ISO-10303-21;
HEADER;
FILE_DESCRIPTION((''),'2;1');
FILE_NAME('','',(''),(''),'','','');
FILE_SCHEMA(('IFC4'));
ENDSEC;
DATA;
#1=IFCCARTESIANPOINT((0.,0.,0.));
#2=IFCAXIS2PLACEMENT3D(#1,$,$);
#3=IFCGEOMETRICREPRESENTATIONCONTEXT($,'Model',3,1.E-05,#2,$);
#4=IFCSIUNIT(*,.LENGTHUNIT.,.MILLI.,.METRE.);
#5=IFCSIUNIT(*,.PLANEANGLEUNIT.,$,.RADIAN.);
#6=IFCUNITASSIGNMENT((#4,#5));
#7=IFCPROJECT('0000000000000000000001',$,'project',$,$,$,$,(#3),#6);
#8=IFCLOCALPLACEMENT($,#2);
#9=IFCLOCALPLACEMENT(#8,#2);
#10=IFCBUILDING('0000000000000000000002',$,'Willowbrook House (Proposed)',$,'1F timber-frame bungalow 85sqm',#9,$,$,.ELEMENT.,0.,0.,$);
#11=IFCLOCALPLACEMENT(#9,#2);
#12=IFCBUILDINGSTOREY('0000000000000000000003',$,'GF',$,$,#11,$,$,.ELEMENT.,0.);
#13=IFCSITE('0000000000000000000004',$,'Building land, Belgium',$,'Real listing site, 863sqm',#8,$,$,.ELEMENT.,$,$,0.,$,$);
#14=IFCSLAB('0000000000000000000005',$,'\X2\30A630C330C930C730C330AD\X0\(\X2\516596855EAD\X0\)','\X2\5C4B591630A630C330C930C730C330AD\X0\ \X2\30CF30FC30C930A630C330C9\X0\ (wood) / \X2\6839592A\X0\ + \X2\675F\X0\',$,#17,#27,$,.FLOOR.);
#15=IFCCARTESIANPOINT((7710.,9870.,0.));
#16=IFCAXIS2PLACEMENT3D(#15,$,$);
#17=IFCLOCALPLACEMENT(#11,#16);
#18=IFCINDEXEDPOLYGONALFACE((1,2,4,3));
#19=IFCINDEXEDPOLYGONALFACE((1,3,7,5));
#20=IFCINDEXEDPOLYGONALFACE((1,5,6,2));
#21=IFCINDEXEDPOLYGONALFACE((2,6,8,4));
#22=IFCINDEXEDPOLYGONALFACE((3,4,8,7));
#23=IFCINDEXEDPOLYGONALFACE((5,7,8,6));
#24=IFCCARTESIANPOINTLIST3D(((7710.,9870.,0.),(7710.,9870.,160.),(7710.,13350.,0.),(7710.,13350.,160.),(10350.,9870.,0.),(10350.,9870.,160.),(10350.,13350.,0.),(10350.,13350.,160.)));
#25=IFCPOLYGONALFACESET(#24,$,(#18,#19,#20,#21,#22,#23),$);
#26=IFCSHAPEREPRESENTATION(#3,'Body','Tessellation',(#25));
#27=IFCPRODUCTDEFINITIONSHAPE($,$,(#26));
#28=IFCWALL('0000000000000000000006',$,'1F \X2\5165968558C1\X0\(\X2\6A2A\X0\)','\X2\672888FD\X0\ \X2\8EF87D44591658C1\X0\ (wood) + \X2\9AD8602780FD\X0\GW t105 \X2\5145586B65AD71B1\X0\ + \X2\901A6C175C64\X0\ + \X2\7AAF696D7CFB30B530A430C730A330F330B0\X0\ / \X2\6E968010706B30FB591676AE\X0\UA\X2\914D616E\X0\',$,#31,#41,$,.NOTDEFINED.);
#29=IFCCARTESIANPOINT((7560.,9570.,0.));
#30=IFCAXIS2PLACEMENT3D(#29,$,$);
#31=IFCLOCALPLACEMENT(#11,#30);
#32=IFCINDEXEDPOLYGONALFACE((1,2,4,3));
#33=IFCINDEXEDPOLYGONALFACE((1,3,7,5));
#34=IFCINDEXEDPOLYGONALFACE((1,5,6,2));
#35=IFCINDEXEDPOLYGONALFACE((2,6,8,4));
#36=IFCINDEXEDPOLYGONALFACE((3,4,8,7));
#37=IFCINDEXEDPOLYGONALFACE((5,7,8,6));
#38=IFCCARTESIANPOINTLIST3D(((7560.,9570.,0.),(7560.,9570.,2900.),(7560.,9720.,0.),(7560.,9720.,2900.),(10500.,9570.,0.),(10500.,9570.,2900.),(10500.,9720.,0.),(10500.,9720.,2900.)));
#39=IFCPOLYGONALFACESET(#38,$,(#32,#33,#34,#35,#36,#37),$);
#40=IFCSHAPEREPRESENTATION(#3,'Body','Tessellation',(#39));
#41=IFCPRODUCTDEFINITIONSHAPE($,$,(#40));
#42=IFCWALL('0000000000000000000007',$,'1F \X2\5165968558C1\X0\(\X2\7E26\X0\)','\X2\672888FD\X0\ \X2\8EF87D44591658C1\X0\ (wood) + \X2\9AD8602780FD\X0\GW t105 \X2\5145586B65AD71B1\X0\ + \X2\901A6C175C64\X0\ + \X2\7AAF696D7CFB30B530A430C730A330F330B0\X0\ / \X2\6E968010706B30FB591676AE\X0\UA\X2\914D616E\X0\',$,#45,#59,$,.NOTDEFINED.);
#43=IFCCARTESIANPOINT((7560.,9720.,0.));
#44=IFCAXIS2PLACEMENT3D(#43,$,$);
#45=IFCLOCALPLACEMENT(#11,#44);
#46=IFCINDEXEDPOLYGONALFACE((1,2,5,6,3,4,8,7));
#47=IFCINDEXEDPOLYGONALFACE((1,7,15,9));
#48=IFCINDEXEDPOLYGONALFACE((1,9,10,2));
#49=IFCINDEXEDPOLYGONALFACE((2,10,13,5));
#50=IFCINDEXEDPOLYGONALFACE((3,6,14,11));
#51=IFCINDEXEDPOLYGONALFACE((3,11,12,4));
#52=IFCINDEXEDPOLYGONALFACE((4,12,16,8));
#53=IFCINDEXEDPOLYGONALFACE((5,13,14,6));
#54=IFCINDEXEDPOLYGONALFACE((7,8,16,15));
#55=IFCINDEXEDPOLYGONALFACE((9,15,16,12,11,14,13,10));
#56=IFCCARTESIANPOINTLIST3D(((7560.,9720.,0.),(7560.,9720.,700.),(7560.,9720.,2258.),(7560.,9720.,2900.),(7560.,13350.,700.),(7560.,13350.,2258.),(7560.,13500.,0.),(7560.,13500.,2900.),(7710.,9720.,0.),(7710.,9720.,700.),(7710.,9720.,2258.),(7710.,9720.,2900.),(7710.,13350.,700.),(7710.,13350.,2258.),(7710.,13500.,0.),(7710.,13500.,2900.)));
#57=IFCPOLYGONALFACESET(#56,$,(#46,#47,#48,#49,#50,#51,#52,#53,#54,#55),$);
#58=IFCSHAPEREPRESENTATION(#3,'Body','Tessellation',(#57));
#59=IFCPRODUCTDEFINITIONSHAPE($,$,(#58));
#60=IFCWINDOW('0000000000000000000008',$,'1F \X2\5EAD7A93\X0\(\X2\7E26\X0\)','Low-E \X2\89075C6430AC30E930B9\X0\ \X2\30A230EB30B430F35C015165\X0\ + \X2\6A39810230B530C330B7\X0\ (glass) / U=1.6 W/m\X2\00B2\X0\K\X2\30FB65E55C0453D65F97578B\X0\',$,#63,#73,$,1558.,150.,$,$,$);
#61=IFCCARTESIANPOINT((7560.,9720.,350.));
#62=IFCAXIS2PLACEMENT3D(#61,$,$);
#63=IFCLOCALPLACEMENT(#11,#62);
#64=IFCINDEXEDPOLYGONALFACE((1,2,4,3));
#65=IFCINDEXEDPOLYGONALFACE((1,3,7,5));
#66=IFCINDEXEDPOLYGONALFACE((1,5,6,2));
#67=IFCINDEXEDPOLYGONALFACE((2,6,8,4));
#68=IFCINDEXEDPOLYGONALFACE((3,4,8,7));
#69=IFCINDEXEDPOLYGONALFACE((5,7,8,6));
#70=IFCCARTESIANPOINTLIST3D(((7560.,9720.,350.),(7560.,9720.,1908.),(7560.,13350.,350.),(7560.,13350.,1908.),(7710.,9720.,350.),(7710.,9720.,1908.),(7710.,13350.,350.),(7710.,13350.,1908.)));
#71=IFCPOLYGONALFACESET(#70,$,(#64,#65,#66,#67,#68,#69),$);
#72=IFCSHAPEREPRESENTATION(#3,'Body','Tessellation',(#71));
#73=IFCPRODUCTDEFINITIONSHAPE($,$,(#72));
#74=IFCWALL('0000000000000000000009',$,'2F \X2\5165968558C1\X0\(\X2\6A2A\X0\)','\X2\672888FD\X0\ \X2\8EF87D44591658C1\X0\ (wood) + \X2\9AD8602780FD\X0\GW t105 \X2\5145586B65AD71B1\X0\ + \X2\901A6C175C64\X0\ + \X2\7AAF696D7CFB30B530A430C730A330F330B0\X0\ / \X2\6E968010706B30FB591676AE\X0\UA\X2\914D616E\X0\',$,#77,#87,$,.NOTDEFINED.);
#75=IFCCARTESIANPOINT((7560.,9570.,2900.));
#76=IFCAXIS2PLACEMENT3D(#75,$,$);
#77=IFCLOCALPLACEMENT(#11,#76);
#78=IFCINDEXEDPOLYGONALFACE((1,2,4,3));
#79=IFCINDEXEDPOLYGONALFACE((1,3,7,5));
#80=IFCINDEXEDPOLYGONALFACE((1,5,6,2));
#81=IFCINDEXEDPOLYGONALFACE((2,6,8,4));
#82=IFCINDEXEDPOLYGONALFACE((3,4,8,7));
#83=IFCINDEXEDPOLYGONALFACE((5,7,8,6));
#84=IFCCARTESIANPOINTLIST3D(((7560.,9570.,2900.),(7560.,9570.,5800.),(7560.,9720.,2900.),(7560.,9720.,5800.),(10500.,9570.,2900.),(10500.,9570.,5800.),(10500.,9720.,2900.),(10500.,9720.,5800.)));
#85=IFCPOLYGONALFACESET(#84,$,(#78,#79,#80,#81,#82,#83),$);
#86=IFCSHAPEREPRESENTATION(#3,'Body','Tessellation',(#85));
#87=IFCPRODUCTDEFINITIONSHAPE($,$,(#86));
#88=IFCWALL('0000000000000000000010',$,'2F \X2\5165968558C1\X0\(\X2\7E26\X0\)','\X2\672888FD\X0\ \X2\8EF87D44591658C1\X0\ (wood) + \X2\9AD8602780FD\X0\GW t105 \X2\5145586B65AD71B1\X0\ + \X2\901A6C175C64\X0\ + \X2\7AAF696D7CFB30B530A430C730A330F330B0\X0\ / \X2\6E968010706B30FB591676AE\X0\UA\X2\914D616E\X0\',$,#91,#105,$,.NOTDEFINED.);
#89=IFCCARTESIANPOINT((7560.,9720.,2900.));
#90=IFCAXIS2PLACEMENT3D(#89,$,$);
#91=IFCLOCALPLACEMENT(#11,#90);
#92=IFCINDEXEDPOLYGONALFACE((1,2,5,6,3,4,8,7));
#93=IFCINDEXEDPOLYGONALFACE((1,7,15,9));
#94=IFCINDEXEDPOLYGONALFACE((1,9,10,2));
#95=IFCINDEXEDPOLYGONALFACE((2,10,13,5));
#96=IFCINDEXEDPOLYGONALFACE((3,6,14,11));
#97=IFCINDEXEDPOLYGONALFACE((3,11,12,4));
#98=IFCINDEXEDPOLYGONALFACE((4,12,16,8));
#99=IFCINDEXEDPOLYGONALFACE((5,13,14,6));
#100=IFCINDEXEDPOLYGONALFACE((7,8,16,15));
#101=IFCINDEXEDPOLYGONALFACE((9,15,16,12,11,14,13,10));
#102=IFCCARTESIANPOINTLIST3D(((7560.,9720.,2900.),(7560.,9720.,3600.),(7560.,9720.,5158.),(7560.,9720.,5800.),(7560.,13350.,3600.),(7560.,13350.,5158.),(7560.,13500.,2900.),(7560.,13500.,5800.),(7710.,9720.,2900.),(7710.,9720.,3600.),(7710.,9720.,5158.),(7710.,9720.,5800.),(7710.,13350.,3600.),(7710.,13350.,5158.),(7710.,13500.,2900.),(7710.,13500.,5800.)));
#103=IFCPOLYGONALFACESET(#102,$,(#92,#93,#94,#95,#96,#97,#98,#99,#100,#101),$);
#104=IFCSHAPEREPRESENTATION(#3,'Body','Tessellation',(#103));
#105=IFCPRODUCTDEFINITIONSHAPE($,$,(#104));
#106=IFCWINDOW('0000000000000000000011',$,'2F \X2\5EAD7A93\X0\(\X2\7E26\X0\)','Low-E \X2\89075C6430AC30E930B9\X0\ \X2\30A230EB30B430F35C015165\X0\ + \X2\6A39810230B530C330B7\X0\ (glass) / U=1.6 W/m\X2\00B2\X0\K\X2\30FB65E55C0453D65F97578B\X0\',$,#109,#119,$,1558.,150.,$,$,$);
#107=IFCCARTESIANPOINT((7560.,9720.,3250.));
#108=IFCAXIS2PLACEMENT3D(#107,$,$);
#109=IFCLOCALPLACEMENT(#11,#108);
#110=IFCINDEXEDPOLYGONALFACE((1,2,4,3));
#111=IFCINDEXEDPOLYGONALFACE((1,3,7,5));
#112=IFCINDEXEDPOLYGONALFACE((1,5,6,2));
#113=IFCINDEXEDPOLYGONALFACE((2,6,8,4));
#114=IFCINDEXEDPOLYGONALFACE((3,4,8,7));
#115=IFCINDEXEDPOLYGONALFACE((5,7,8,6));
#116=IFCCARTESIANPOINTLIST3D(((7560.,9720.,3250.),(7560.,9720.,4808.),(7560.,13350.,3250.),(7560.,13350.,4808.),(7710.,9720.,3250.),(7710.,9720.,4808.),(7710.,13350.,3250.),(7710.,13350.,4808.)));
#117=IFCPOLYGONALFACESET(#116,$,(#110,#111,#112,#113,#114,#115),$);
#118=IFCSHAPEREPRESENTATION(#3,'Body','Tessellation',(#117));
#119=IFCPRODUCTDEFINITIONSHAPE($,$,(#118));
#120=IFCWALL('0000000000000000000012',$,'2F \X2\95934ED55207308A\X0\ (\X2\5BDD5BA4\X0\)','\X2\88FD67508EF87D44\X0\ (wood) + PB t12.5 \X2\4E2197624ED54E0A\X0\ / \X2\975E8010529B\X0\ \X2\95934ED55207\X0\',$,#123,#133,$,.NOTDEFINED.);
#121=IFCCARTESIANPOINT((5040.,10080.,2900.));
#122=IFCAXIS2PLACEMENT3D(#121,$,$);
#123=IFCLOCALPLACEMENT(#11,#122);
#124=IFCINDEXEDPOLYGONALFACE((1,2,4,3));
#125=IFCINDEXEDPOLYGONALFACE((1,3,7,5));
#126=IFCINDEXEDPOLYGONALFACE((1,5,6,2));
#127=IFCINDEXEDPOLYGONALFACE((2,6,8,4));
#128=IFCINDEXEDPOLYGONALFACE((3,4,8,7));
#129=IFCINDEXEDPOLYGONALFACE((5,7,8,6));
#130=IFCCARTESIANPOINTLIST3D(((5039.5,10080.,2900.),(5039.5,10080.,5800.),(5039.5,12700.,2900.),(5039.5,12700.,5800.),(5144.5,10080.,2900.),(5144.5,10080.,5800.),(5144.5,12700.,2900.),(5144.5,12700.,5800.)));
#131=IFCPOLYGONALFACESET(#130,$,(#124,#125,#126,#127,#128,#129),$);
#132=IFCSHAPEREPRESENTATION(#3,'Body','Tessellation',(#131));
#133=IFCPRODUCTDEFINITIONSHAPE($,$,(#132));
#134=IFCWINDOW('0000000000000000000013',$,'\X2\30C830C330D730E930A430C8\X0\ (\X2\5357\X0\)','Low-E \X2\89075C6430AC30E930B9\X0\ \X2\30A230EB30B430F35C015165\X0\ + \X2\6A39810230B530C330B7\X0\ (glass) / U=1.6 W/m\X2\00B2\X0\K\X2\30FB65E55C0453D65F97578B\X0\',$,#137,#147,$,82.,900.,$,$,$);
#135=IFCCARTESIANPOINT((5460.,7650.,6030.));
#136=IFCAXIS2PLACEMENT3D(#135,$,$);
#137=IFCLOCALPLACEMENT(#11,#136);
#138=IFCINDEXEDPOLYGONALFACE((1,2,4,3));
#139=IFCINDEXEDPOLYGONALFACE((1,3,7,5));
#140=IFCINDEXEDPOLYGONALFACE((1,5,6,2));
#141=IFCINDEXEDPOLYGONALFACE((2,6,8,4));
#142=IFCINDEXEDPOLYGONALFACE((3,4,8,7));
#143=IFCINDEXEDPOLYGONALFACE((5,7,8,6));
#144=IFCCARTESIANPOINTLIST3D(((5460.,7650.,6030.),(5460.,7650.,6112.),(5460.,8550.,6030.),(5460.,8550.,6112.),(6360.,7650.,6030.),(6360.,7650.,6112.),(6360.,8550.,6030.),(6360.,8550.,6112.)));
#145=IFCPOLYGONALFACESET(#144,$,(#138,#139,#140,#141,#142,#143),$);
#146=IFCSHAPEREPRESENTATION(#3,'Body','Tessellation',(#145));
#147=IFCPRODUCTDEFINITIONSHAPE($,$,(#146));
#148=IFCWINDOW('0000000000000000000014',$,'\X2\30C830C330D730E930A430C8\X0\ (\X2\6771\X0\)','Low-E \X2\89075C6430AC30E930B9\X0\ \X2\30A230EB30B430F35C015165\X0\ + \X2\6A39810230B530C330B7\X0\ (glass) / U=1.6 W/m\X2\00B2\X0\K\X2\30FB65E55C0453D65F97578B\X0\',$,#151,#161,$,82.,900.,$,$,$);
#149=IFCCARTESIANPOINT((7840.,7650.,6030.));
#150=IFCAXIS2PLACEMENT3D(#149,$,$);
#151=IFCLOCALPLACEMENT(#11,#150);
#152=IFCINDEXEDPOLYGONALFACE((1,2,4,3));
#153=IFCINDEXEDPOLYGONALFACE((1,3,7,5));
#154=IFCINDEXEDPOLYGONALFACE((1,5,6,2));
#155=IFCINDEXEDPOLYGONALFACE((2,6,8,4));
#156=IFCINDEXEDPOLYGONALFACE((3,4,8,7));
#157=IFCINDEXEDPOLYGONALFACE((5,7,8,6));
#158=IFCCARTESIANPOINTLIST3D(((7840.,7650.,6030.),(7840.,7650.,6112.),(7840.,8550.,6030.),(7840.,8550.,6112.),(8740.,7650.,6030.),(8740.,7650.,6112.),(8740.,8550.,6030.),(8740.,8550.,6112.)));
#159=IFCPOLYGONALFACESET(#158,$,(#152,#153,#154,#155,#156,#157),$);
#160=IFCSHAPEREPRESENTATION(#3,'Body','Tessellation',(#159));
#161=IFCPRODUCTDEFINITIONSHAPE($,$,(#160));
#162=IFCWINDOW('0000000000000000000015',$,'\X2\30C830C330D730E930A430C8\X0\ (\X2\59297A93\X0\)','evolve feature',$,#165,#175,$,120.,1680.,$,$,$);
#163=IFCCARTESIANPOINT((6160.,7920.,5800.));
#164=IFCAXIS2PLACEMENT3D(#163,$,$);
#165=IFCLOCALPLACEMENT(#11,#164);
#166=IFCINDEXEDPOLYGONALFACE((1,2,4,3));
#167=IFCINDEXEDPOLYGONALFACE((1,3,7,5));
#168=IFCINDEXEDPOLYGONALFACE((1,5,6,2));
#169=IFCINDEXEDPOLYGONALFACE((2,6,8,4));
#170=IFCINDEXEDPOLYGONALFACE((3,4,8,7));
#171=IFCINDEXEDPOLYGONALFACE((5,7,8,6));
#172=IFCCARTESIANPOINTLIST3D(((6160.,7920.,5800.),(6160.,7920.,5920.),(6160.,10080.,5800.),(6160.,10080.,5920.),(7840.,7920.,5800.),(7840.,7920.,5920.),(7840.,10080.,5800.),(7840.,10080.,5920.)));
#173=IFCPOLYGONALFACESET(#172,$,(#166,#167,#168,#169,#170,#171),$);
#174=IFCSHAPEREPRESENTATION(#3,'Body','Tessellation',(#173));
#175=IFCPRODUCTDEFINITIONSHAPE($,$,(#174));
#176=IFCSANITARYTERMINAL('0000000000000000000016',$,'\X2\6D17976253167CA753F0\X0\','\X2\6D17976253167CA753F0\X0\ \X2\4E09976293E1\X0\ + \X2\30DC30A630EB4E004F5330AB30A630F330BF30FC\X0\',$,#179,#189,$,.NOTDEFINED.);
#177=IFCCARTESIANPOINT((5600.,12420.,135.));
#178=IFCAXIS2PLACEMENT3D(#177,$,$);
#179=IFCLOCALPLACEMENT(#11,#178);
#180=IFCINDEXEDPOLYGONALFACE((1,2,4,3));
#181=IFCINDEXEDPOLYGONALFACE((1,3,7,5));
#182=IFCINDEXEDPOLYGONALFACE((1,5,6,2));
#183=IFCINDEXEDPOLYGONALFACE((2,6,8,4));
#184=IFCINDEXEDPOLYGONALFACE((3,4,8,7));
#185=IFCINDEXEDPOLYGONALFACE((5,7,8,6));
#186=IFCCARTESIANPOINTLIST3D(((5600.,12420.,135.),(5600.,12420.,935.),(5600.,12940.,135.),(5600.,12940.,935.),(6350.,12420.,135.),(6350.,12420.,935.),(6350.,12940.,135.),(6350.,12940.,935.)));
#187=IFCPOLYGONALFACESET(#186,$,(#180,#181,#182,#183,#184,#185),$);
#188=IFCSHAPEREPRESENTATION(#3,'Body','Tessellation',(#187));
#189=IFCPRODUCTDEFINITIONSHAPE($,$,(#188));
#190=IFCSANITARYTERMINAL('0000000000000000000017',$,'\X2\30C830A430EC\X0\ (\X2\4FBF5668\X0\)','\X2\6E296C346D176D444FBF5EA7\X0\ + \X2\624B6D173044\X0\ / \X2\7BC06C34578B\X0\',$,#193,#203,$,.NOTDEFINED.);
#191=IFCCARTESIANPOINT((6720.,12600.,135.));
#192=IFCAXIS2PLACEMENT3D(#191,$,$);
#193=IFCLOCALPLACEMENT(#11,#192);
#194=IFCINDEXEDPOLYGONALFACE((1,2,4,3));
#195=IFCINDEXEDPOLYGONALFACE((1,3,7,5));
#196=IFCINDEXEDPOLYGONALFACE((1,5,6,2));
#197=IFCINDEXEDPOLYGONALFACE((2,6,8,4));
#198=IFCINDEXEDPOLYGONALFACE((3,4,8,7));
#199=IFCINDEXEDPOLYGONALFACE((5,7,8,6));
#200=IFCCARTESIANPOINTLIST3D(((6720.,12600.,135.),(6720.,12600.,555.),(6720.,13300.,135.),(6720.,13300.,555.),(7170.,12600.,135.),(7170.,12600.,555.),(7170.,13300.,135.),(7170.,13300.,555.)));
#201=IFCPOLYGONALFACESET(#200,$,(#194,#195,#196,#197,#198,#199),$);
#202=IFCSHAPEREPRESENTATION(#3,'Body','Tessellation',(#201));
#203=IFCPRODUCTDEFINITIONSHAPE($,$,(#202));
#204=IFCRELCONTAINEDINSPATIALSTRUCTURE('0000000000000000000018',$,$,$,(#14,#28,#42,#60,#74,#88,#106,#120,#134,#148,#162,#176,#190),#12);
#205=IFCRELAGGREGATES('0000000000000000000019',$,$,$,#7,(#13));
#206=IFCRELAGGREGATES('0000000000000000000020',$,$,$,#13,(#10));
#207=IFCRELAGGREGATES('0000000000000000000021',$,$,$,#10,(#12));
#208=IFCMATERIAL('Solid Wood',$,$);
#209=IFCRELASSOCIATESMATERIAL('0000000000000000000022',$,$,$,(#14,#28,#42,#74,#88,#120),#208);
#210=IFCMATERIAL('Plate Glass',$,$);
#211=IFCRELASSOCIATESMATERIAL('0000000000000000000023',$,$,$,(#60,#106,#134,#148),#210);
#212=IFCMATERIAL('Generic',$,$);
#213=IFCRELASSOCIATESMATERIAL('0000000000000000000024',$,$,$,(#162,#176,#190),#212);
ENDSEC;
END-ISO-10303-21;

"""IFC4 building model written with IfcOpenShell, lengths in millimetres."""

from ifc_helpers import new_model, si_unit, frame, frame_2d, origin, place, context, project, spatial, rectangle, extrude, material, element, fill, save


model = new_model("IFC4")

# Units and contexts
model_context = context("Model", 3, precision=1e-05, world=origin())
ifc_project = project(units=[si_unit("LENGTHUNIT", "METRE", prefix="MILLI"), si_unit("PLANEANGLEUNIT", "RADIAN")], contexts=[model_context])

# Site, building, storey
site_placement = place(None, origin())
site = spatial("IfcSite", under=ifc_project, at=site_placement, Name="Building land, Belgium", ObjectType="Real listing site, 863sqm", CompositionType="ELEMENT", RefElevation=0.0)
building_placement = place(site_placement, origin())
building = spatial("IfcBuilding", under=site, at=building_placement, Name="Willowbrook House (Proposed)", ObjectType="1F timber-frame bungalow 85sqm", CompositionType="ELEMENT", ElevationOfRefHeight=0.0, ElevationOfTerrain=0.0)
storey_placement = place(building_placement, origin())
storey = spatial("IfcBuildingStorey", under=building, at=storey_placement, Name="GF", CompositionType="ELEMENT", Elevation=0.0)

# Slab
ifc_material_1 = material(Name="Solid Wood")
slab_placement = place(storey_placement, frame((7710.0, 9870.0, 0.0)))
element("IfcSlab", 1, at=slab_placement, inside=storey, material=ifc_material_1, Name="ウッドデッキ(入隅庭)", Description="屋外ウッドデッキ ハードウッド (wood) / 根太 + 束", PredefinedType="FLOOR", context=model_context, shape_type="SweptSolid", body=[
    extrude(rectangle(XDim=2640.0, YDim=3480.0, at=frame_2d((1320.0, 1740.0))), frame((7710.0, 9870.0, 0.0)), (0.0, 0.0, 1.0), 160.0),
])

# Wall
wall_1_placement = place(storey_placement, frame((7560.0, 9570.0, 0.0)))
element("IfcWall", 2, at=wall_1_placement, inside=storey, material=ifc_material_1, Name="1F 入隅壁(横)", Description="木製 軸組外壁 (wood) + 高性能GW t105 充填断熱 + 通気層 + 窯業系サイディング / 準耐火・外皮UA配慮", PredefinedType="NOTDEFINED", context=model_context, shape_type="SweptSolid", body=[
    extrude(rectangle(XDim=2940.0, YDim=150.0, at=frame_2d((1470.0, 75.0))), frame((7560.0, 9570.0, 0.0)), (0.0, 0.0, 1.0), 2900.0),
])

# Wall, opening, window
wall_2_placement = place(storey_placement, frame((7560.0, 9720.0, 0.0)))
wall_2 = element("IfcWall", 3, at=wall_2_placement, inside=storey, material=ifc_material_1, Name="1F 入隅壁(縦)", Description="木製 軸組外壁 (wood) + 高性能GW t105 充填断熱 + 通気層 + 窯業系サイディング / 準耐火・外皮UA配慮", PredefinedType="NOTDEFINED", context=model_context, shape_type="SweptSolid", body=[
    extrude(rectangle(XDim=150.0, YDim=3780.0, at=frame_2d((75.0, 1890.0))), frame((7560.0, 9720.0, 0.0)), (0.0, 0.0, 1.0), 2900.0),
])
opening_1_placement = place(storey_placement, frame((7560.0, 9720.0, 350.0)))
opening_1 = element("IfcOpeningElement", 4, at=opening_1_placement, cuts=wall_2, PredefinedType="NOTDEFINED", context=model_context, shape_type="SweptSolid", body=[
    extrude(rectangle(XDim=150.0, YDim=3630.0, at=frame_2d((75.0, 1815.0))), frame((7560.0, 9720.0, 350.0)), (0.0, 0.0, 1.0), 1558.0),
])
ifc_material_2 = material(Name="Plate Glass")
window_1_placement = place(storey_placement, frame((7560.0, 9720.0, 350.0)))
window_1 = element("IfcWindow", 5, at=window_1_placement, inside=storey, material=ifc_material_2, Name="1F 庭窓(縦)", Description="Low-E 複層ガラス アルゴン封入 + 樹脂サッシ (glass) / U=1.6 W/m²K・日射取得型", OverallHeight=1558.0, OverallWidth=150.0, context=model_context, shape_type="SweptSolid", body=[
    extrude(rectangle(XDim=150.0, YDim=3630.0, at=frame_2d((75.0, 1815.0))), frame((7560.0, 9720.0, 350.0)), (0.0, 0.0, 1.0), 1558.0),
])
fill(opening_1, window_1)

# Wall
wall_3_placement = place(storey_placement, frame((7560.0, 9570.0, 2900.0)))
element("IfcWall", 6, at=wall_3_placement, inside=storey, material=ifc_material_1, Name="2F 入隅壁(横)", Description="木製 軸組外壁 (wood) + 高性能GW t105 充填断熱 + 通気層 + 窯業系サイディング / 準耐火・外皮UA配慮", PredefinedType="NOTDEFINED", context=model_context, shape_type="SweptSolid", body=[
    extrude(rectangle(XDim=2940.0, YDim=150.0, at=frame_2d((1470.0, 75.0))), frame((7560.0, 9570.0, 2900.0)), (0.0, 0.0, 1.0), 2900.0),
])

# Wall, opening, window
wall_4_placement = place(storey_placement, frame((7560.0, 9720.0, 2900.0)))
wall_4 = element("IfcWall", 7, at=wall_4_placement, inside=storey, material=ifc_material_1, Name="2F 入隅壁(縦)", Description="木製 軸組外壁 (wood) + 高性能GW t105 充填断熱 + 通気層 + 窯業系サイディング / 準耐火・外皮UA配慮", PredefinedType="NOTDEFINED", context=model_context, shape_type="SweptSolid", body=[
    extrude(rectangle(XDim=150.0, YDim=3780.0, at=frame_2d((75.0, 1890.0))), frame((7560.0, 9720.0, 2900.0)), (0.0, 0.0, 1.0), 2900.0),
])
opening_2_placement = place(storey_placement, frame((7560.0, 9720.0, 3250.0)))
opening_2 = element("IfcOpeningElement", 8, at=opening_2_placement, cuts=wall_4, PredefinedType="NOTDEFINED", context=model_context, shape_type="SweptSolid", body=[
    extrude(rectangle(XDim=150.0, YDim=3630.0, at=frame_2d((75.0, 1815.0))), frame((7560.0, 9720.0, 3250.0)), (0.0, 0.0, 1.0), 1558.0),
])
window_2_placement = place(storey_placement, frame((7560.0, 9720.0, 3250.0)))
window_2 = element("IfcWindow", 9, at=window_2_placement, inside=storey, material=ifc_material_2, Name="2F 庭窓(縦)", Description="Low-E 複層ガラス アルゴン封入 + 樹脂サッシ (glass) / U=1.6 W/m²K・日射取得型", OverallHeight=1558.0, OverallWidth=150.0, context=model_context, shape_type="SweptSolid", body=[
    extrude(rectangle(XDim=150.0, YDim=3630.0, at=frame_2d((75.0, 1815.0))), frame((7560.0, 9720.0, 3250.0)), (0.0, 0.0, 1.0), 1558.0),
])
fill(opening_2, window_2)

# Wall
wall_5_placement = place(storey_placement, frame((5040.0, 10080.0, 2900.0)))
element("IfcWall", 10, at=wall_5_placement, inside=storey, material=ifc_material_1, Name="2F 間仕切り (寝室)", Description="製材軸組 (wood) + PB t12.5 両面仕上 / 非耐力 間仕切", PredefinedType="NOTDEFINED", context=model_context, shape_type="SweptSolid", body=[
    extrude(rectangle(XDim=105.0, YDim=2620.0, at=frame_2d((52.0, 1310.0))), frame((5040.0, 10080.0, 2900.0)), (0.0, 0.0, 1.0), 2900.0),
])

# Windows
window_3_placement = place(storey_placement, frame((5460.0, 7650.0, 6030.0)))
element("IfcWindow", 11, at=window_3_placement, inside=storey, material=ifc_material_2, Name="トップライト (南)", Description="Low-E 複層ガラス アルゴン封入 + 樹脂サッシ (glass) / U=1.6 W/m²K・日射取得型", OverallHeight=82.0, OverallWidth=900.0, context=model_context, shape_type="SweptSolid", body=[
    extrude(rectangle(XDim=900.0, YDim=900.0, at=frame_2d((450.0, 450.0))), frame((5460.0, 7650.0, 6030.0)), (0.0, 0.0, 1.0), 82.0),
])
window_4_placement = place(storey_placement, frame((7840.0, 7650.0, 6030.0)))
element("IfcWindow", 12, at=window_4_placement, inside=storey, material=ifc_material_2, Name="トップライト (東)", Description="Low-E 複層ガラス アルゴン封入 + 樹脂サッシ (glass) / U=1.6 W/m²K・日射取得型", OverallHeight=82.0, OverallWidth=900.0, context=model_context, shape_type="SweptSolid", body=[
    extrude(rectangle(XDim=900.0, YDim=900.0, at=frame_2d((450.0, 450.0))), frame((7840.0, 7650.0, 6030.0)), (0.0, 0.0, 1.0), 82.0),
])
ifc_material_3 = material(Name="Generic")
window_5_placement = place(storey_placement, frame((6160.0, 7920.0, 5800.0)))
element("IfcWindow", 13, at=window_5_placement, inside=storey, material=ifc_material_3, Name="トップライト (天窓)", Description="evolve feature", OverallHeight=120.0, OverallWidth=1680.0, context=model_context, shape_type="SweptSolid", body=[
    extrude(rectangle(XDim=1680.0, YDim=2160.0, at=frame_2d((840.0, 1080.0))), frame((6160.0, 7920.0, 5800.0)), (0.0, 0.0, 1.0), 120.0),
])

# Sanitary terminals
sanitary_terminal_1_placement = place(storey_placement, frame((5600.0, 12420.0, 135.0)))
element("IfcSanitaryTerminal", 14, at=sanitary_terminal_1_placement, inside=storey, material=ifc_material_3, Name="洗面化粧台", Description="洗面化粧台 三面鏡 + ボウル一体カウンター", PredefinedType="NOTDEFINED", context=model_context, shape_type="SweptSolid", body=[
    extrude(rectangle(XDim=750.0, YDim=520.0, at=frame_2d((375.0, 260.0))), frame((5600.0, 12420.0, 135.0)), (0.0, 0.0, 1.0), 800.0),
])
sanitary_terminal_2_placement = place(storey_placement, frame((6720.0, 12600.0, 135.0)))
element("IfcSanitaryTerminal", 15, at=sanitary_terminal_2_placement, inside=storey, material=ifc_material_3, Name="トイレ (便器)", Description="温水洗浄便座 + 手洗い / 節水型", PredefinedType="NOTDEFINED", context=model_context, shape_type="SweptSolid", body=[
    extrude(rectangle(XDim=450.0, YDim=700.0, at=frame_2d((225.0, 350.0))), frame((6720.0, 12600.0, 135.0)), (0.0, 0.0, 1.0), 420.0),
])

save(model, "model.ifc")
